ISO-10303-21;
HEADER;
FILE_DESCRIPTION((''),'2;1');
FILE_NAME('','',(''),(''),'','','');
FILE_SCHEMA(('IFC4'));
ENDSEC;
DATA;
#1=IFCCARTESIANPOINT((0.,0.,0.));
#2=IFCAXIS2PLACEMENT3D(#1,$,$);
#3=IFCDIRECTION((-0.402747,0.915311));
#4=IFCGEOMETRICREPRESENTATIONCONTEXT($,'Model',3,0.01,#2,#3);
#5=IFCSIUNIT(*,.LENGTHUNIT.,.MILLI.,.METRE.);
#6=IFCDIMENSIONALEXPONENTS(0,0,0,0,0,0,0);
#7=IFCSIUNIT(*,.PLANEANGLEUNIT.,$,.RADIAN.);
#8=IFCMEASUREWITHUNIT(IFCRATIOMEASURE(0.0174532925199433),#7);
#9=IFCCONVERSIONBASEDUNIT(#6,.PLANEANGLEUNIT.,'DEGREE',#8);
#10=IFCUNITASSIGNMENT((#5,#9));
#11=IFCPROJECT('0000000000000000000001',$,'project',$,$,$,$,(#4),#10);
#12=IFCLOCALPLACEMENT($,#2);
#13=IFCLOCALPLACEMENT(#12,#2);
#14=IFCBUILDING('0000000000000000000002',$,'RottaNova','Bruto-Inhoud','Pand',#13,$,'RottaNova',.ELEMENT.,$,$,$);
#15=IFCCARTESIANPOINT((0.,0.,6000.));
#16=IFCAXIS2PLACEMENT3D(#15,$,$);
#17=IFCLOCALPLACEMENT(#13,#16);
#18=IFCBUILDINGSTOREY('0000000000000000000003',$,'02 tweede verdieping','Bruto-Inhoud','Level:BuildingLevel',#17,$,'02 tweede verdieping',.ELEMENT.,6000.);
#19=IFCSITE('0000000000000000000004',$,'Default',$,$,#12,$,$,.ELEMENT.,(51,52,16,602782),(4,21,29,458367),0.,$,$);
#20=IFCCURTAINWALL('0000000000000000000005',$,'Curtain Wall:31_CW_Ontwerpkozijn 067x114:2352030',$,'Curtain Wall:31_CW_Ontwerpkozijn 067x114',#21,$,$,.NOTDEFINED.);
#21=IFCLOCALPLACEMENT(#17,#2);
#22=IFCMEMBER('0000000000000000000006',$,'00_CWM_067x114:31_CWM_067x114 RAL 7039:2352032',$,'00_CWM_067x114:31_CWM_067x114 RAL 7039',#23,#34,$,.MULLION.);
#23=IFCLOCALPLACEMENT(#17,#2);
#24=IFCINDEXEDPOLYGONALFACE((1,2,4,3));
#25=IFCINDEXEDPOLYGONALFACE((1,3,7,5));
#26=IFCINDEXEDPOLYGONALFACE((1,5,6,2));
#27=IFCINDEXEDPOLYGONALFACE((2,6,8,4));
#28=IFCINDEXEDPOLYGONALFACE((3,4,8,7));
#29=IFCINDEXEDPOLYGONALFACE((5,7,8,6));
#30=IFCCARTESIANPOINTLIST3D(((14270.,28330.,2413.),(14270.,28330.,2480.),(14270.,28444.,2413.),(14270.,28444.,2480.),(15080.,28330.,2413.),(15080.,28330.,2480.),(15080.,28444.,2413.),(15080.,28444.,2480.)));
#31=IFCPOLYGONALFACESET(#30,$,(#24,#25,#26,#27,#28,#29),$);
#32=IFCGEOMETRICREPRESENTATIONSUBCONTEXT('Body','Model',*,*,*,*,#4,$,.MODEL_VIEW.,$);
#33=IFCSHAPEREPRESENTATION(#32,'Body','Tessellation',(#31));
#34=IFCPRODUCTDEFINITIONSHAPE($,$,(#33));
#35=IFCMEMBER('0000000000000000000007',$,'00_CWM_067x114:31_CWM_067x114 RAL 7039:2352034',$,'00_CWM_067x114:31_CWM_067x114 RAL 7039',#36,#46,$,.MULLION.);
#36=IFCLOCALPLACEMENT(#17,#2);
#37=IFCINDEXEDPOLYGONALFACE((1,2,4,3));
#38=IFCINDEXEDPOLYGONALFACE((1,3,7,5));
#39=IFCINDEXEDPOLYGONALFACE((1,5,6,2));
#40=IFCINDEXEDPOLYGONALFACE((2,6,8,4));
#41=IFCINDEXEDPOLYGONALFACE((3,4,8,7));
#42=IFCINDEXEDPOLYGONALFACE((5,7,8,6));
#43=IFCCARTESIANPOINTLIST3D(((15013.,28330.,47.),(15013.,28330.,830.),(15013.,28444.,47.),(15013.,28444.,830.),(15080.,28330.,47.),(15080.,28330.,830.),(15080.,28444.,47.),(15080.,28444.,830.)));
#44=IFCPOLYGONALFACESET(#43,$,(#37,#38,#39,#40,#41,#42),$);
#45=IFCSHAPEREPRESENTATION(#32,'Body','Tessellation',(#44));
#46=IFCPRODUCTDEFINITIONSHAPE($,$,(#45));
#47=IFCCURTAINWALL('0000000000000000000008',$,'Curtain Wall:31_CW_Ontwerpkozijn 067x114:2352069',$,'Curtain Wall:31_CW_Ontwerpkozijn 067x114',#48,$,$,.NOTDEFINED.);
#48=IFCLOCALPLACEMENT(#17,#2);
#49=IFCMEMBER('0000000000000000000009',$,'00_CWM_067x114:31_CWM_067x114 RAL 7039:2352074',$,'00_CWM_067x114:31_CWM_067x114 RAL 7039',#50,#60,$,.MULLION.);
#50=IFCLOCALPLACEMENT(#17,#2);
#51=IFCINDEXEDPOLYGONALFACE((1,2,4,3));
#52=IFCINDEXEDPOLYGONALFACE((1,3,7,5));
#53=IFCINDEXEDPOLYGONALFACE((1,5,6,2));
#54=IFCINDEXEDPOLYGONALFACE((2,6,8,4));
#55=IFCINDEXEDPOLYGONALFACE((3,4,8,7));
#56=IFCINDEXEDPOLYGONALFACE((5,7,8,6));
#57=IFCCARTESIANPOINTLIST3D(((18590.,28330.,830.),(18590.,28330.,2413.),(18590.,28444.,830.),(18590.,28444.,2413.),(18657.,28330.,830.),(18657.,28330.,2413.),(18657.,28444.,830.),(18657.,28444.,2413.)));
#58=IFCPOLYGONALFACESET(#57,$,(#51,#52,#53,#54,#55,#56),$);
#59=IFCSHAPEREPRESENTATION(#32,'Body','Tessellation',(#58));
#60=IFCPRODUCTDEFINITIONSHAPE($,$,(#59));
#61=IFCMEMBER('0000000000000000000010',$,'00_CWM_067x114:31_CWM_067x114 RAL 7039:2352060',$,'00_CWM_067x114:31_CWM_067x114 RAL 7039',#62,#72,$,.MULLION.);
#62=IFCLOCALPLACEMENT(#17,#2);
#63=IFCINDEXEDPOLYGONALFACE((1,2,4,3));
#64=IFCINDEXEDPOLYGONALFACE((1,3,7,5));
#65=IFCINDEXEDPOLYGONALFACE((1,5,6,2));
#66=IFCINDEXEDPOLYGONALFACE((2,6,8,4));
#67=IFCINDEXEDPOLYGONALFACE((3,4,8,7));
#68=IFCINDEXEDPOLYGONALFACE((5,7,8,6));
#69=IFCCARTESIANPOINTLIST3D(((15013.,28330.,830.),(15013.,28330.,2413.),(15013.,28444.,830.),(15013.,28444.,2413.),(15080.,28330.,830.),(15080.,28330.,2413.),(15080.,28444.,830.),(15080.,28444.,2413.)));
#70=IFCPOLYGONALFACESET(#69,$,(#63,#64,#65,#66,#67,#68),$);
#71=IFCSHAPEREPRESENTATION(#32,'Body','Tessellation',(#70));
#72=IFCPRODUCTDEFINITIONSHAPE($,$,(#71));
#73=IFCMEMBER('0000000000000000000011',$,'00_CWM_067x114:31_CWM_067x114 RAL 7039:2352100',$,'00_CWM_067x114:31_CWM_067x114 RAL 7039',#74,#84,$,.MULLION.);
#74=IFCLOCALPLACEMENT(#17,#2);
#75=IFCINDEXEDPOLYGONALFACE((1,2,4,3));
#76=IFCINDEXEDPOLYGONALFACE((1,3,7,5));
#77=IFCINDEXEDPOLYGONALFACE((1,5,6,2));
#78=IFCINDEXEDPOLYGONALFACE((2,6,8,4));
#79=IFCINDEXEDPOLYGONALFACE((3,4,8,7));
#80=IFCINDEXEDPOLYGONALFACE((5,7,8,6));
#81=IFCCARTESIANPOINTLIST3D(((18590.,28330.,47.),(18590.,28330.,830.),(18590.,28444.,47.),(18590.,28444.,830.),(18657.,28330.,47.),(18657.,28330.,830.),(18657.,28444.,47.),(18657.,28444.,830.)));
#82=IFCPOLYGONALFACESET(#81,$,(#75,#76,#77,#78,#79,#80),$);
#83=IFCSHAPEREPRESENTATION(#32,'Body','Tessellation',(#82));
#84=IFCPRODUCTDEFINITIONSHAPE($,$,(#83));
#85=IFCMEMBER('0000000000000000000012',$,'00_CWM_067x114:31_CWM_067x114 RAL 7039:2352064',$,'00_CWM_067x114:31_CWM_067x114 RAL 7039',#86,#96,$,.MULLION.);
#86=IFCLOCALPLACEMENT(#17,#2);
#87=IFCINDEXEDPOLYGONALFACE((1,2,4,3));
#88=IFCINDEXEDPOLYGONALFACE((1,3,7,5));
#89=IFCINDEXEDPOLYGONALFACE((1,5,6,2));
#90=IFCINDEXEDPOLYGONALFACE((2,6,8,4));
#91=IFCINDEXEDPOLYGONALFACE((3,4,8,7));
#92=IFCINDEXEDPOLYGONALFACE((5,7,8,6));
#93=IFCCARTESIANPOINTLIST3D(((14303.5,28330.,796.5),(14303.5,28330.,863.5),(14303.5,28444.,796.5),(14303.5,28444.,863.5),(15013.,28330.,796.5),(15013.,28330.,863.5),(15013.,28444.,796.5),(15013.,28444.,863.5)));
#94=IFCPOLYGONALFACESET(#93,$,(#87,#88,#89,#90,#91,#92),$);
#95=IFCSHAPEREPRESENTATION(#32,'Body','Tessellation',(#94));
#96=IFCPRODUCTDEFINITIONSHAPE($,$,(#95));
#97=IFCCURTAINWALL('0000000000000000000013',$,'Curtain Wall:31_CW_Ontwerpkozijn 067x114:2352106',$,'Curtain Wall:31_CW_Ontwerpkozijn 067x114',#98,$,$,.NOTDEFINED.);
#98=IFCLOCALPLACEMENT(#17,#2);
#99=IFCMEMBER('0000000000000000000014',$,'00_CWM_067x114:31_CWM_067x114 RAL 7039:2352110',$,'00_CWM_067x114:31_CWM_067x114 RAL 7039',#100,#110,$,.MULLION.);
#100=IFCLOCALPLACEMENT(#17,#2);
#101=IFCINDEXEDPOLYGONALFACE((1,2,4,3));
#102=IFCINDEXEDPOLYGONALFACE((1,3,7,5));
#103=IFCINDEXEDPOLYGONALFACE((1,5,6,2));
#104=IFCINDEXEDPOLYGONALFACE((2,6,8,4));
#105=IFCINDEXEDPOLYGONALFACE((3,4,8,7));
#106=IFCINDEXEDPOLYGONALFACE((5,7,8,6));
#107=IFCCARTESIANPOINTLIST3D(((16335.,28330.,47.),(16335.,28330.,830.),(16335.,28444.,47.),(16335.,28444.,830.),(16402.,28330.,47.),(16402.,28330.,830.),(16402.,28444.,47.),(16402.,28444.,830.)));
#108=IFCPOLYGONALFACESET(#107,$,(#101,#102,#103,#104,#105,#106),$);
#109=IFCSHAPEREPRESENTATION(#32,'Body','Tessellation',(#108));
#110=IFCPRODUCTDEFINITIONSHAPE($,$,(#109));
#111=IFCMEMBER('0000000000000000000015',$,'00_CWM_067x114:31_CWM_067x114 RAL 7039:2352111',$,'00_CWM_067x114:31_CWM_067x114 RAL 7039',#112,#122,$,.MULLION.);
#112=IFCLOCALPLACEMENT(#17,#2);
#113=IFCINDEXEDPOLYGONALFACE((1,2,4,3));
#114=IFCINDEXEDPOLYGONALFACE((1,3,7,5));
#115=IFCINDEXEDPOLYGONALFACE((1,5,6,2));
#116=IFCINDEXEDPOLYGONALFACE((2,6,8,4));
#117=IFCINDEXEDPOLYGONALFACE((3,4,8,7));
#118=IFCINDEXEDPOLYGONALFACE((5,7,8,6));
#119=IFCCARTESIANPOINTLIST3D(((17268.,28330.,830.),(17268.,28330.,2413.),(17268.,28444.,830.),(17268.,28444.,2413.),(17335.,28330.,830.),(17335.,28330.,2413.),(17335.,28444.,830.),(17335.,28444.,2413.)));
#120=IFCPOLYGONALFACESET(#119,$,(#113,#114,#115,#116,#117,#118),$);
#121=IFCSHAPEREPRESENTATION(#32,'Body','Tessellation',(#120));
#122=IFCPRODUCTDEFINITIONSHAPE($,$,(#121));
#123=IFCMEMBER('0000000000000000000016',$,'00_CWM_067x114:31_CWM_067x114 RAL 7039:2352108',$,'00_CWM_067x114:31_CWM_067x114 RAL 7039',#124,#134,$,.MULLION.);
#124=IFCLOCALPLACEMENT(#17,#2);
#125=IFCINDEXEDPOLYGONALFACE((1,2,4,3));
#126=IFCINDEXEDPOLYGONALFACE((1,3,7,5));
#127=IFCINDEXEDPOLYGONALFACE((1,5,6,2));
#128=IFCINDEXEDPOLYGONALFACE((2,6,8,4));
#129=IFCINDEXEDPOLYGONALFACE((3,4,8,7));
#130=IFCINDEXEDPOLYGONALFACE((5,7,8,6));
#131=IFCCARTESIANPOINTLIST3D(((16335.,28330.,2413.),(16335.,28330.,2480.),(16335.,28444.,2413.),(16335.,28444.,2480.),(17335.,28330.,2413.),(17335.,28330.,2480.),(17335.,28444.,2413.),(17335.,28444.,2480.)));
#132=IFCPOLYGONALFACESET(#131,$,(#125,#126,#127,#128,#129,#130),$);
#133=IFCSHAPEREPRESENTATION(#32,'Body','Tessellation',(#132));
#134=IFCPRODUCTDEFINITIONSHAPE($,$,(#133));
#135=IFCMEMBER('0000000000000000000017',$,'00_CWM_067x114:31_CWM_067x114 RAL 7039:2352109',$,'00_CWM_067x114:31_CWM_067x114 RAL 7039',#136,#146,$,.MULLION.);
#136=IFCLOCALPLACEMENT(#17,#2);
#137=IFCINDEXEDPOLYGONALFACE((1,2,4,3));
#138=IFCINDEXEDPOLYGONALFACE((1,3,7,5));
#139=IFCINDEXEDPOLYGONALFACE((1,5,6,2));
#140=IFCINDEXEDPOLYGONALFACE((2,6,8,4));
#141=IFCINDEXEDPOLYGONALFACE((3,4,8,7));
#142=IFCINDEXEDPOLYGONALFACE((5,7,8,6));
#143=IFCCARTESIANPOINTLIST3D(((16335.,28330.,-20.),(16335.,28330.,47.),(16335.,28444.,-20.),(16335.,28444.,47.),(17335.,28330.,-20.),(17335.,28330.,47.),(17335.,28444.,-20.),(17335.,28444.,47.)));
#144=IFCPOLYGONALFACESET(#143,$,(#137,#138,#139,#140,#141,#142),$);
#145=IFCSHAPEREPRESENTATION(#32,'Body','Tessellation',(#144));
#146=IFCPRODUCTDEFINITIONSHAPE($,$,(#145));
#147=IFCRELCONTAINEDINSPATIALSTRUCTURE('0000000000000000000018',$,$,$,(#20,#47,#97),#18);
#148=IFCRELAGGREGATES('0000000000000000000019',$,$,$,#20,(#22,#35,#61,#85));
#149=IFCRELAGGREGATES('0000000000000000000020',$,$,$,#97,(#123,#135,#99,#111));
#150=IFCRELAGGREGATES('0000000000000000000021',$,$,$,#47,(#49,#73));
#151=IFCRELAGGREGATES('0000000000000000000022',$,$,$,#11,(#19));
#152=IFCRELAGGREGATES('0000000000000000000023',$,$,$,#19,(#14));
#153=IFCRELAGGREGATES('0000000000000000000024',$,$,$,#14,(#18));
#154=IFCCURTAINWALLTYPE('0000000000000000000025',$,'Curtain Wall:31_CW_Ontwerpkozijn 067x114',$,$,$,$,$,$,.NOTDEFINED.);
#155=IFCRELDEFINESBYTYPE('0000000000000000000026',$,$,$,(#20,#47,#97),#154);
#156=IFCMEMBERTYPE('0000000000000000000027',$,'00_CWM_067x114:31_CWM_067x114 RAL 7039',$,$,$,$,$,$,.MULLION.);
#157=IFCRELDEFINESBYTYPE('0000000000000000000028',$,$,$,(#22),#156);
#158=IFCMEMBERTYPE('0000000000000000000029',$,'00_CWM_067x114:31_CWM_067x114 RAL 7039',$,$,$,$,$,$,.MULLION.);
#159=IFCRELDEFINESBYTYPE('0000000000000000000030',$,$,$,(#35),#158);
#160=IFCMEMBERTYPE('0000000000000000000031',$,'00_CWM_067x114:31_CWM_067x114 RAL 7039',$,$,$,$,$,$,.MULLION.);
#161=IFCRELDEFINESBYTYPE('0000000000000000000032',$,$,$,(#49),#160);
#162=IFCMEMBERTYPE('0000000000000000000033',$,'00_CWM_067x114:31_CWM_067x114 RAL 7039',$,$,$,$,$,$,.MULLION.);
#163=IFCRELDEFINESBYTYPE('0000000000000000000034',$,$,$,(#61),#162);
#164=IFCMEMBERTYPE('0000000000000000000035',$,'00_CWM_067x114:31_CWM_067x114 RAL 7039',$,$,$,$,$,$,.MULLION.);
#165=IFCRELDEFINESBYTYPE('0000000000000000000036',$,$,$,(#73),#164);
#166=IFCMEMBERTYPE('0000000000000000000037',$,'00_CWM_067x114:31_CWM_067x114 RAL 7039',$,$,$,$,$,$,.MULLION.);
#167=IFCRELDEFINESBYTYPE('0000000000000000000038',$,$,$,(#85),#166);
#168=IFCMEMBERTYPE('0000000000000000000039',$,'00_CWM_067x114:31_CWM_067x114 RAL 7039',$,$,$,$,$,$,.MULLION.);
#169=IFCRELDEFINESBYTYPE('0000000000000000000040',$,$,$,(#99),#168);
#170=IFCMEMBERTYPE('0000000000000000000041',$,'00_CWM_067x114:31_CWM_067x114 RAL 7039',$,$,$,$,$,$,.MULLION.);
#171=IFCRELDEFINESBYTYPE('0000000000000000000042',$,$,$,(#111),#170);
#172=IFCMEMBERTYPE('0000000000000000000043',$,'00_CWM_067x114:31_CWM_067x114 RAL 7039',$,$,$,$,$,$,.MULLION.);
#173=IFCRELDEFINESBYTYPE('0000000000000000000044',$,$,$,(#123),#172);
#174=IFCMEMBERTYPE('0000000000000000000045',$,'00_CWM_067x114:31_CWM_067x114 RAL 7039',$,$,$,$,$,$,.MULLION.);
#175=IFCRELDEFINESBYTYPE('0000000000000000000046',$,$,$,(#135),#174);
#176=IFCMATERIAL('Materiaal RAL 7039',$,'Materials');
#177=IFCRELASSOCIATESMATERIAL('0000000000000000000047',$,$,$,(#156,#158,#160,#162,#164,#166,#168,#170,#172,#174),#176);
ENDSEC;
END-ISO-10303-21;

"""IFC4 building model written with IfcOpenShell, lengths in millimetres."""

from ifc_helpers import new_model, entity, si_unit, converted_unit, direction, frame, frame_2d, origin, origin_2d_with_axis, place, context, subcontext, project, spatial, rectangle, extrude, source, transform, mapped, material, material_profile, profile_set, type_object, type_shapes, element, aggregate, save


model = new_model("IFC4")

# Units and contexts
model_context = context("Model", 3, precision=0.01, world=origin(), true_north=direction((-0.402747, 0.915311)))
body_context = subcontext(model_context, "Body", "Model", "MODEL_VIEW")
ifc_project = project(units=[si_unit("LENGTHUNIT", "METRE", prefix="MILLI"), converted_unit("PLANEANGLEUNIT", "DEGREE", entity("IfcRatioMeasure", 0.0174532925199433), si_unit("PLANEANGLEUNIT", "RADIAN"), dimensions=[0, 0, 0, 0, 0, 0, 0])], contexts=[model_context])

# Site, building, storey
site_placement = place(None, origin())
site = spatial("IfcSite", under=ifc_project, at=site_placement, Name="Default", CompositionType="ELEMENT", RefLatitude=(51, 52, 16, 602782), RefLongitude=(4, 21, 29, 458367), RefElevation=0.0)
building_placement = place(site_placement, origin())
building = spatial("IfcBuilding", under=site, at=building_placement, Name="RottaNova", Description="Bruto-Inhoud", ObjectType="Pand", LongName="RottaNova", CompositionType="ELEMENT")
storey_placement = place(building_placement, frame((0.0, 0.0, 6000.0)))
storey = spatial("IfcBuildingStorey", under=building, at=storey_placement, Name="02 tweede verdieping", Description="Bruto-Inhoud", ObjectType="Level:BuildingLevel", LongName="02 tweede verdieping", CompositionType="ELEMENT", Elevation=6000.0)

# Curtain wall, members
curtain_wall_type = type_object("IfcCurtainWallType", Name="Curtain Wall:31_CW_Ontwerpkozijn 067x114", PredefinedType="NOTDEFINED")
curtain_wall_1_placement = place(storey_placement, frame((0.0, 0.0, -6000.0)))
curtain_wall_1 = element("IfcCurtainWall", 1, at=curtain_wall_1_placement, inside=storey, type_object=curtain_wall_type, Name="Curtain Wall:31_CW_Ontwerpkozijn 067x114:2352030", ObjectType="Curtain Wall:31_CW_Ontwerpkozijn 067x114", PredefinedType="NOTDEFINED")
ifc_material_1 = material(Name="Materiaal RAL 7039", Category="Materials")
ifc_material_profile = material_profile(ifc_material_1, rectangle(XDim=114.0, YDim=67.0, at=origin_2d_with_axis()), Name="31_CWM_067x114 RAL 7039")
ifc_profile_set = profile_set([ifc_material_profile], Name="31_CWM_067x114 RAL 7039")
member_type_1 = type_object("IfcMemberType", Name="00_CWM_067x114:31_CWM_067x114 RAL 7039", PredefinedType="MULLION", material=ifc_profile_set)
shared_shape_1 = source(origin(), body_context, "Body", "SweptSolid", [
    extrude(rectangle(XDim=114.0, YDim=67.0, at=frame_2d((0.0, 0.0), x_axis=(1.0, 0.0))), frame((-33.5, -57.0, -810.0), z_axis=(0.0, 0.0, 1.0), x_axis=(0.0, -1.0, 0.0)), (0.0, 0.0, 1.0), 810.0),
])
type_shapes(member_type_1, [shared_shape_1])
member_1_placement = place(curtain_wall_1_placement, frame((15080.0, 28330.0, 8480.0), z_axis=(1.0, 0.0, 0.0), x_axis=(0.0, 0.0, 1.0)))
member_1 = element("IfcMember", 2, at=member_1_placement, type_object=member_type_1, Name="00_CWM_067x114:31_CWM_067x114 RAL 7039:2352032", ObjectType="00_CWM_067x114:31_CWM_067x114 RAL 7039", PredefinedType="MULLION", context=body_context, shape_type="MappedRepresentation", body=[
    mapped(shared_shape_1, transform((0.0, 0.0, 0.0), scale=1.0)),
])
member_type_2 = type_object("IfcMemberType", Name="00_CWM_067x114:31_CWM_067x114 RAL 7039", PredefinedType="MULLION", material=ifc_profile_set)
shared_shape_2 = source(origin(), body_context, "Body", "SweptSolid", [
    extrude(rectangle(XDim=114.0, YDim=67.0, at=frame_2d((0.0, 0.0), x_axis=(1.0, 0.0))), frame((-33.5, -57.0, -783.0), z_axis=(0.0, 0.0, 1.0), x_axis=(0.0, -1.0, 0.0)), (0.0, 0.0, 1.0), 783.0),
])
type_shapes(member_type_2, [shared_shape_2])
member_2_placement = place(curtain_wall_1_placement, frame((15080.0, 28330.0, 6047.0), z_axis=(0.0, 0.0, -1.0), x_axis=(1.0, 0.0, 0.0)))
member_2 = element("IfcMember", 3, at=member_2_placement, type_object=member_type_2, Name="00_CWM_067x114:31_CWM_067x114 RAL 7039:2352034", ObjectType="00_CWM_067x114:31_CWM_067x114 RAL 7039", PredefinedType="MULLION", context=body_context, shape_type="MappedRepresentation", body=[
    mapped(shared_shape_2, transform((0.0, 0.0, 0.0), scale=1.0)),
])

# Curtain wall, member
curtain_wall_2_placement = place(storey_placement, frame((0.0, 0.0, -6000.0)))
curtain_wall_2 = element("IfcCurtainWall", 4, at=curtain_wall_2_placement, inside=storey, type_object=curtain_wall_type, Name="Curtain Wall:31_CW_Ontwerpkozijn 067x114:2352069", ObjectType="Curtain Wall:31_CW_Ontwerpkozijn 067x114", PredefinedType="NOTDEFINED")
member_type_3 = type_object("IfcMemberType", Name="00_CWM_067x114:31_CWM_067x114 RAL 7039", PredefinedType="MULLION", material=ifc_profile_set)
shared_shape_3 = source(origin(), body_context, "Body", "SweptSolid", [
    extrude(rectangle(XDim=114.0, YDim=67.0, at=frame_2d((0.0, 0.0), x_axis=(1.0, 0.0))), frame((-33.5, -57.0, -1583.0), z_axis=(0.0, 0.0, 1.0), x_axis=(0.0, -1.0, 0.0)), (0.0, 0.0, 1.0), 1583.0),
])
type_shapes(member_type_3, [shared_shape_3])
member_3_placement = place(curtain_wall_2_placement, frame((18590.0, 28330.0, 8413.0), z_axis=(0.0, 0.0, 1.0), x_axis=(-1.0, 0.0, 0.0)))
member_3 = element("IfcMember", 5, at=member_3_placement, type_object=member_type_3, Name="00_CWM_067x114:31_CWM_067x114 RAL 7039:2352074", ObjectType="00_CWM_067x114:31_CWM_067x114 RAL 7039", PredefinedType="MULLION", context=body_context, shape_type="MappedRepresentation", body=[
    mapped(shared_shape_3, transform((0.0, 0.0, 0.0), scale=1.0)),
])

# Members
member_type_4 = type_object("IfcMemberType", Name="00_CWM_067x114:31_CWM_067x114 RAL 7039", PredefinedType="MULLION", material=ifc_profile_set)
shared_shape_4 = source(origin(), body_context, "Body", "SweptSolid", [
    extrude(rectangle(XDim=114.0, YDim=67.0, at=frame_2d((0.0, 0.0), x_axis=(1.0, 0.0))), frame((-33.5, -57.0, -1583.0), z_axis=(0.0, 0.0, 1.0), x_axis=(0.0, -1.0, 0.0)), (0.0, 0.0, 1.0), 1583.0),
])
type_shapes(member_type_4, [shared_shape_4])
member_4_placement = place(curtain_wall_1_placement, frame((15080.0, 28330.0, 6830.0), z_axis=(0.0, 0.0, -1.0), x_axis=(1.0, 0.0, 0.0)))
member_4 = element("IfcMember", 6, at=member_4_placement, type_object=member_type_4, Name="00_CWM_067x114:31_CWM_067x114 RAL 7039:2352060", ObjectType="00_CWM_067x114:31_CWM_067x114 RAL 7039", PredefinedType="MULLION", context=body_context, shape_type="MappedRepresentation", body=[
    mapped(shared_shape_4, transform((0.0, 0.0, 0.0), scale=1.0)),
])
member_type_5 = type_object("IfcMemberType", Name="00_CWM_067x114:31_CWM_067x114 RAL 7039", PredefinedType="MULLION", material=ifc_profile_set)
shared_shape_5 = source(origin(), body_context, "Body", "SweptSolid", [
    extrude(rectangle(XDim=114.0, YDim=67.0, at=frame_2d((0.0, 0.0), x_axis=(1.0, 0.0))), frame((-33.5, -57.0, -783.0), z_axis=(0.0, 0.0, 1.0), x_axis=(0.0, -1.0, 0.0)), (0.0, 0.0, 1.0), 783.0),
])
type_shapes(member_type_5, [shared_shape_5])
member_5_placement = place(curtain_wall_2_placement, frame((18590.0, 28330.0, 6830.0), z_axis=(0.0, 0.0, 1.0), x_axis=(-1.0, 0.0, 0.0)))
member_5 = element("IfcMember", 7, at=member_5_placement, type_object=member_type_5, Name="00_CWM_067x114:31_CWM_067x114 RAL 7039:2352100", ObjectType="00_CWM_067x114:31_CWM_067x114 RAL 7039", PredefinedType="MULLION", context=body_context, shape_type="MappedRepresentation", body=[
    mapped(shared_shape_5, transform((0.0, 0.0, 0.0), scale=1.0)),
])
member_type_6 = type_object("IfcMemberType", Name="00_CWM_067x114:31_CWM_067x114 RAL 7039", PredefinedType="MULLION", material=ifc_profile_set)
shared_shape_6 = source(origin(), body_context, "Body", "SweptSolid", [
    extrude(rectangle(XDim=114.0, YDim=67.0, at=origin_2d_with_axis()), frame((0.0, -57.0, -709.5), z_axis=(0.0, 0.0, 1.0), x_axis=(0.0, -1.0, 0.0)), (0.0, 0.0, 1.0), 709.5),
])
type_shapes(member_type_6, [shared_shape_6])
member_6_placement = place(curtain_wall_1_placement, frame((15013.0, 28330.0, 6830.0), z_axis=(1.0, 0.0, 0.0), x_axis=(0.0, 0.0, 1.0)))
member_6 = element("IfcMember", 8, at=member_6_placement, type_object=member_type_6, Name="00_CWM_067x114:31_CWM_067x114 RAL 7039:2352064", ObjectType="00_CWM_067x114:31_CWM_067x114 RAL 7039", PredefinedType="MULLION", context=body_context, shape_type="MappedRepresentation", body=[
    mapped(shared_shape_6, transform((0.0, 0.0, 0.0), scale=1.0)),
])
aggregate(curtain_wall_1, [member_1, member_2, member_4, member_6])

# Curtain wall, members
curtain_wall_3_placement = place(storey_placement, frame((0.0, 0.0, -6000.0)))
curtain_wall_3 = element("IfcCurtainWall", 9, at=curtain_wall_3_placement, inside=storey, type_object=curtain_wall_type, Name="Curtain Wall:31_CW_Ontwerpkozijn 067x114:2352106", ObjectType="Curtain Wall:31_CW_Ontwerpkozijn 067x114", PredefinedType="NOTDEFINED")
member_type_7 = type_object("IfcMemberType", Name="00_CWM_067x114:31_CWM_067x114 RAL 7039", PredefinedType="MULLION", material=ifc_profile_set)
shared_shape_7 = source(origin(), body_context, "Body", "SweptSolid", [
    extrude(rectangle(XDim=114.0, YDim=67.0, at=origin_2d_with_axis()), frame((-33.5, 57.0, -783.0), z_axis=(0.0, 0.0, 1.0), x_axis=(0.0, -1.0, 0.0)), (0.0, 0.0, 1.0), 783.0),
])
type_shapes(member_type_7, [shared_shape_7])
member_7_placement = place(curtain_wall_3_placement, frame((16335.0, 28330.0, 6047.0), z_axis=(0.0, 0.0, -1.0), x_axis=(-1.0, 0.0, 0.0)))
member_7 = element("IfcMember", 10, at=member_7_placement, type_object=member_type_7, Name="00_CWM_067x114:31_CWM_067x114 RAL 7039:2352110", ObjectType="00_CWM_067x114:31_CWM_067x114 RAL 7039", PredefinedType="MULLION", context=body_context, shape_type="MappedRepresentation", body=[
    mapped(shared_shape_7, transform((0.0, 0.0, 0.0), scale=1.0)),
])
member_type_8 = type_object("IfcMemberType", Name="00_CWM_067x114:31_CWM_067x114 RAL 7039", PredefinedType="MULLION", material=ifc_profile_set)
shared_shape_8 = source(origin(), body_context, "Body", "SweptSolid", [
    extrude(rectangle(XDim=114.0, YDim=67.0, at=origin_2d_with_axis()), frame((-33.5, 57.0, -1583.0), z_axis=(0.0, 0.0, 1.0), x_axis=(0.0, -1.0, 0.0)), (0.0, 0.0, 1.0), 1583.0),
])
type_shapes(member_type_8, [shared_shape_8])
member_8_placement = place(curtain_wall_3_placement, frame((17335.0, 28330.0, 8413.0)))
member_8 = element("IfcMember", 11, at=member_8_placement, type_object=member_type_8, Name="00_CWM_067x114:31_CWM_067x114 RAL 7039:2352111", ObjectType="00_CWM_067x114:31_CWM_067x114 RAL 7039", PredefinedType="MULLION", context=body_context, shape_type="MappedRepresentation", body=[
    mapped(shared_shape_8, transform((0.0, 0.0, 0.0), scale=1.0)),
])
member_type_9 = type_object("IfcMemberType", Name="00_CWM_067x114:31_CWM_067x114 RAL 7039", PredefinedType="MULLION", material=ifc_profile_set)
shared_shape_9 = source(origin(), body_context, "Body", "SweptSolid", [
    extrude(rectangle(XDim=114.0, YDim=67.0, at=origin_2d_with_axis()), frame((-33.5, 57.0, -1000.0), z_axis=(0.0, 0.0, 1.0), x_axis=(0.0, -1.0, 0.0)), (0.0, 0.0, 1.0), 1000.0),
])
type_shapes(member_type_9, [shared_shape_9])
member_9_placement = place(curtain_wall_3_placement, frame((16335.0, 28330.0, 8480.0), z_axis=(-1.0, 0.0, 0.0), x_axis=(0.0, 0.0, 1.0)))
member_9 = element("IfcMember", 12, at=member_9_placement, type_object=member_type_9, Name="00_CWM_067x114:31_CWM_067x114 RAL 7039:2352108", ObjectType="00_CWM_067x114:31_CWM_067x114 RAL 7039", PredefinedType="MULLION", context=body_context, shape_type="MappedRepresentation", body=[
    mapped(shared_shape_9, transform((0.0, 0.0, 0.0), scale=1.0)),
])
member_type_10 = type_object("IfcMemberType", Name="00_CWM_067x114:31_CWM_067x114 RAL 7039", PredefinedType="MULLION", material=ifc_profile_set)
shared_shape_10 = source(origin(), body_context, "Body", "SweptSolid", [
    extrude(rectangle(XDim=114.0, YDim=67.0, at=origin_2d_with_axis()), frame((-33.5, 57.0, -1000.0), z_axis=(0.0, 0.0, 1.0), x_axis=(0.0, -1.0, 0.0)), (0.0, 0.0, 1.0), 1000.0),
])
type_shapes(member_type_10, [shared_shape_10])
member_10_placement = place(curtain_wall_3_placement, frame((17335.0, 28330.0, 5980.0), z_axis=(1.0, 0.0, 0.0), x_axis=(0.0, 0.0, -1.0)))
member_10 = element("IfcMember", 13, at=member_10_placement, type_object=member_type_10, Name="00_CWM_067x114:31_CWM_067x114 RAL 7039:2352109", ObjectType="00_CWM_067x114:31_CWM_067x114 RAL 7039", PredefinedType="MULLION", context=body_context, shape_type="MappedRepresentation", body=[
    mapped(shared_shape_10, transform((0.0, 0.0, 0.0), scale=1.0)),
])

aggregate(curtain_wall_3, [member_9, member_10, member_7, member_8])
aggregate(curtain_wall_2, [member_3, member_5])

save(model, "model.ifc")
